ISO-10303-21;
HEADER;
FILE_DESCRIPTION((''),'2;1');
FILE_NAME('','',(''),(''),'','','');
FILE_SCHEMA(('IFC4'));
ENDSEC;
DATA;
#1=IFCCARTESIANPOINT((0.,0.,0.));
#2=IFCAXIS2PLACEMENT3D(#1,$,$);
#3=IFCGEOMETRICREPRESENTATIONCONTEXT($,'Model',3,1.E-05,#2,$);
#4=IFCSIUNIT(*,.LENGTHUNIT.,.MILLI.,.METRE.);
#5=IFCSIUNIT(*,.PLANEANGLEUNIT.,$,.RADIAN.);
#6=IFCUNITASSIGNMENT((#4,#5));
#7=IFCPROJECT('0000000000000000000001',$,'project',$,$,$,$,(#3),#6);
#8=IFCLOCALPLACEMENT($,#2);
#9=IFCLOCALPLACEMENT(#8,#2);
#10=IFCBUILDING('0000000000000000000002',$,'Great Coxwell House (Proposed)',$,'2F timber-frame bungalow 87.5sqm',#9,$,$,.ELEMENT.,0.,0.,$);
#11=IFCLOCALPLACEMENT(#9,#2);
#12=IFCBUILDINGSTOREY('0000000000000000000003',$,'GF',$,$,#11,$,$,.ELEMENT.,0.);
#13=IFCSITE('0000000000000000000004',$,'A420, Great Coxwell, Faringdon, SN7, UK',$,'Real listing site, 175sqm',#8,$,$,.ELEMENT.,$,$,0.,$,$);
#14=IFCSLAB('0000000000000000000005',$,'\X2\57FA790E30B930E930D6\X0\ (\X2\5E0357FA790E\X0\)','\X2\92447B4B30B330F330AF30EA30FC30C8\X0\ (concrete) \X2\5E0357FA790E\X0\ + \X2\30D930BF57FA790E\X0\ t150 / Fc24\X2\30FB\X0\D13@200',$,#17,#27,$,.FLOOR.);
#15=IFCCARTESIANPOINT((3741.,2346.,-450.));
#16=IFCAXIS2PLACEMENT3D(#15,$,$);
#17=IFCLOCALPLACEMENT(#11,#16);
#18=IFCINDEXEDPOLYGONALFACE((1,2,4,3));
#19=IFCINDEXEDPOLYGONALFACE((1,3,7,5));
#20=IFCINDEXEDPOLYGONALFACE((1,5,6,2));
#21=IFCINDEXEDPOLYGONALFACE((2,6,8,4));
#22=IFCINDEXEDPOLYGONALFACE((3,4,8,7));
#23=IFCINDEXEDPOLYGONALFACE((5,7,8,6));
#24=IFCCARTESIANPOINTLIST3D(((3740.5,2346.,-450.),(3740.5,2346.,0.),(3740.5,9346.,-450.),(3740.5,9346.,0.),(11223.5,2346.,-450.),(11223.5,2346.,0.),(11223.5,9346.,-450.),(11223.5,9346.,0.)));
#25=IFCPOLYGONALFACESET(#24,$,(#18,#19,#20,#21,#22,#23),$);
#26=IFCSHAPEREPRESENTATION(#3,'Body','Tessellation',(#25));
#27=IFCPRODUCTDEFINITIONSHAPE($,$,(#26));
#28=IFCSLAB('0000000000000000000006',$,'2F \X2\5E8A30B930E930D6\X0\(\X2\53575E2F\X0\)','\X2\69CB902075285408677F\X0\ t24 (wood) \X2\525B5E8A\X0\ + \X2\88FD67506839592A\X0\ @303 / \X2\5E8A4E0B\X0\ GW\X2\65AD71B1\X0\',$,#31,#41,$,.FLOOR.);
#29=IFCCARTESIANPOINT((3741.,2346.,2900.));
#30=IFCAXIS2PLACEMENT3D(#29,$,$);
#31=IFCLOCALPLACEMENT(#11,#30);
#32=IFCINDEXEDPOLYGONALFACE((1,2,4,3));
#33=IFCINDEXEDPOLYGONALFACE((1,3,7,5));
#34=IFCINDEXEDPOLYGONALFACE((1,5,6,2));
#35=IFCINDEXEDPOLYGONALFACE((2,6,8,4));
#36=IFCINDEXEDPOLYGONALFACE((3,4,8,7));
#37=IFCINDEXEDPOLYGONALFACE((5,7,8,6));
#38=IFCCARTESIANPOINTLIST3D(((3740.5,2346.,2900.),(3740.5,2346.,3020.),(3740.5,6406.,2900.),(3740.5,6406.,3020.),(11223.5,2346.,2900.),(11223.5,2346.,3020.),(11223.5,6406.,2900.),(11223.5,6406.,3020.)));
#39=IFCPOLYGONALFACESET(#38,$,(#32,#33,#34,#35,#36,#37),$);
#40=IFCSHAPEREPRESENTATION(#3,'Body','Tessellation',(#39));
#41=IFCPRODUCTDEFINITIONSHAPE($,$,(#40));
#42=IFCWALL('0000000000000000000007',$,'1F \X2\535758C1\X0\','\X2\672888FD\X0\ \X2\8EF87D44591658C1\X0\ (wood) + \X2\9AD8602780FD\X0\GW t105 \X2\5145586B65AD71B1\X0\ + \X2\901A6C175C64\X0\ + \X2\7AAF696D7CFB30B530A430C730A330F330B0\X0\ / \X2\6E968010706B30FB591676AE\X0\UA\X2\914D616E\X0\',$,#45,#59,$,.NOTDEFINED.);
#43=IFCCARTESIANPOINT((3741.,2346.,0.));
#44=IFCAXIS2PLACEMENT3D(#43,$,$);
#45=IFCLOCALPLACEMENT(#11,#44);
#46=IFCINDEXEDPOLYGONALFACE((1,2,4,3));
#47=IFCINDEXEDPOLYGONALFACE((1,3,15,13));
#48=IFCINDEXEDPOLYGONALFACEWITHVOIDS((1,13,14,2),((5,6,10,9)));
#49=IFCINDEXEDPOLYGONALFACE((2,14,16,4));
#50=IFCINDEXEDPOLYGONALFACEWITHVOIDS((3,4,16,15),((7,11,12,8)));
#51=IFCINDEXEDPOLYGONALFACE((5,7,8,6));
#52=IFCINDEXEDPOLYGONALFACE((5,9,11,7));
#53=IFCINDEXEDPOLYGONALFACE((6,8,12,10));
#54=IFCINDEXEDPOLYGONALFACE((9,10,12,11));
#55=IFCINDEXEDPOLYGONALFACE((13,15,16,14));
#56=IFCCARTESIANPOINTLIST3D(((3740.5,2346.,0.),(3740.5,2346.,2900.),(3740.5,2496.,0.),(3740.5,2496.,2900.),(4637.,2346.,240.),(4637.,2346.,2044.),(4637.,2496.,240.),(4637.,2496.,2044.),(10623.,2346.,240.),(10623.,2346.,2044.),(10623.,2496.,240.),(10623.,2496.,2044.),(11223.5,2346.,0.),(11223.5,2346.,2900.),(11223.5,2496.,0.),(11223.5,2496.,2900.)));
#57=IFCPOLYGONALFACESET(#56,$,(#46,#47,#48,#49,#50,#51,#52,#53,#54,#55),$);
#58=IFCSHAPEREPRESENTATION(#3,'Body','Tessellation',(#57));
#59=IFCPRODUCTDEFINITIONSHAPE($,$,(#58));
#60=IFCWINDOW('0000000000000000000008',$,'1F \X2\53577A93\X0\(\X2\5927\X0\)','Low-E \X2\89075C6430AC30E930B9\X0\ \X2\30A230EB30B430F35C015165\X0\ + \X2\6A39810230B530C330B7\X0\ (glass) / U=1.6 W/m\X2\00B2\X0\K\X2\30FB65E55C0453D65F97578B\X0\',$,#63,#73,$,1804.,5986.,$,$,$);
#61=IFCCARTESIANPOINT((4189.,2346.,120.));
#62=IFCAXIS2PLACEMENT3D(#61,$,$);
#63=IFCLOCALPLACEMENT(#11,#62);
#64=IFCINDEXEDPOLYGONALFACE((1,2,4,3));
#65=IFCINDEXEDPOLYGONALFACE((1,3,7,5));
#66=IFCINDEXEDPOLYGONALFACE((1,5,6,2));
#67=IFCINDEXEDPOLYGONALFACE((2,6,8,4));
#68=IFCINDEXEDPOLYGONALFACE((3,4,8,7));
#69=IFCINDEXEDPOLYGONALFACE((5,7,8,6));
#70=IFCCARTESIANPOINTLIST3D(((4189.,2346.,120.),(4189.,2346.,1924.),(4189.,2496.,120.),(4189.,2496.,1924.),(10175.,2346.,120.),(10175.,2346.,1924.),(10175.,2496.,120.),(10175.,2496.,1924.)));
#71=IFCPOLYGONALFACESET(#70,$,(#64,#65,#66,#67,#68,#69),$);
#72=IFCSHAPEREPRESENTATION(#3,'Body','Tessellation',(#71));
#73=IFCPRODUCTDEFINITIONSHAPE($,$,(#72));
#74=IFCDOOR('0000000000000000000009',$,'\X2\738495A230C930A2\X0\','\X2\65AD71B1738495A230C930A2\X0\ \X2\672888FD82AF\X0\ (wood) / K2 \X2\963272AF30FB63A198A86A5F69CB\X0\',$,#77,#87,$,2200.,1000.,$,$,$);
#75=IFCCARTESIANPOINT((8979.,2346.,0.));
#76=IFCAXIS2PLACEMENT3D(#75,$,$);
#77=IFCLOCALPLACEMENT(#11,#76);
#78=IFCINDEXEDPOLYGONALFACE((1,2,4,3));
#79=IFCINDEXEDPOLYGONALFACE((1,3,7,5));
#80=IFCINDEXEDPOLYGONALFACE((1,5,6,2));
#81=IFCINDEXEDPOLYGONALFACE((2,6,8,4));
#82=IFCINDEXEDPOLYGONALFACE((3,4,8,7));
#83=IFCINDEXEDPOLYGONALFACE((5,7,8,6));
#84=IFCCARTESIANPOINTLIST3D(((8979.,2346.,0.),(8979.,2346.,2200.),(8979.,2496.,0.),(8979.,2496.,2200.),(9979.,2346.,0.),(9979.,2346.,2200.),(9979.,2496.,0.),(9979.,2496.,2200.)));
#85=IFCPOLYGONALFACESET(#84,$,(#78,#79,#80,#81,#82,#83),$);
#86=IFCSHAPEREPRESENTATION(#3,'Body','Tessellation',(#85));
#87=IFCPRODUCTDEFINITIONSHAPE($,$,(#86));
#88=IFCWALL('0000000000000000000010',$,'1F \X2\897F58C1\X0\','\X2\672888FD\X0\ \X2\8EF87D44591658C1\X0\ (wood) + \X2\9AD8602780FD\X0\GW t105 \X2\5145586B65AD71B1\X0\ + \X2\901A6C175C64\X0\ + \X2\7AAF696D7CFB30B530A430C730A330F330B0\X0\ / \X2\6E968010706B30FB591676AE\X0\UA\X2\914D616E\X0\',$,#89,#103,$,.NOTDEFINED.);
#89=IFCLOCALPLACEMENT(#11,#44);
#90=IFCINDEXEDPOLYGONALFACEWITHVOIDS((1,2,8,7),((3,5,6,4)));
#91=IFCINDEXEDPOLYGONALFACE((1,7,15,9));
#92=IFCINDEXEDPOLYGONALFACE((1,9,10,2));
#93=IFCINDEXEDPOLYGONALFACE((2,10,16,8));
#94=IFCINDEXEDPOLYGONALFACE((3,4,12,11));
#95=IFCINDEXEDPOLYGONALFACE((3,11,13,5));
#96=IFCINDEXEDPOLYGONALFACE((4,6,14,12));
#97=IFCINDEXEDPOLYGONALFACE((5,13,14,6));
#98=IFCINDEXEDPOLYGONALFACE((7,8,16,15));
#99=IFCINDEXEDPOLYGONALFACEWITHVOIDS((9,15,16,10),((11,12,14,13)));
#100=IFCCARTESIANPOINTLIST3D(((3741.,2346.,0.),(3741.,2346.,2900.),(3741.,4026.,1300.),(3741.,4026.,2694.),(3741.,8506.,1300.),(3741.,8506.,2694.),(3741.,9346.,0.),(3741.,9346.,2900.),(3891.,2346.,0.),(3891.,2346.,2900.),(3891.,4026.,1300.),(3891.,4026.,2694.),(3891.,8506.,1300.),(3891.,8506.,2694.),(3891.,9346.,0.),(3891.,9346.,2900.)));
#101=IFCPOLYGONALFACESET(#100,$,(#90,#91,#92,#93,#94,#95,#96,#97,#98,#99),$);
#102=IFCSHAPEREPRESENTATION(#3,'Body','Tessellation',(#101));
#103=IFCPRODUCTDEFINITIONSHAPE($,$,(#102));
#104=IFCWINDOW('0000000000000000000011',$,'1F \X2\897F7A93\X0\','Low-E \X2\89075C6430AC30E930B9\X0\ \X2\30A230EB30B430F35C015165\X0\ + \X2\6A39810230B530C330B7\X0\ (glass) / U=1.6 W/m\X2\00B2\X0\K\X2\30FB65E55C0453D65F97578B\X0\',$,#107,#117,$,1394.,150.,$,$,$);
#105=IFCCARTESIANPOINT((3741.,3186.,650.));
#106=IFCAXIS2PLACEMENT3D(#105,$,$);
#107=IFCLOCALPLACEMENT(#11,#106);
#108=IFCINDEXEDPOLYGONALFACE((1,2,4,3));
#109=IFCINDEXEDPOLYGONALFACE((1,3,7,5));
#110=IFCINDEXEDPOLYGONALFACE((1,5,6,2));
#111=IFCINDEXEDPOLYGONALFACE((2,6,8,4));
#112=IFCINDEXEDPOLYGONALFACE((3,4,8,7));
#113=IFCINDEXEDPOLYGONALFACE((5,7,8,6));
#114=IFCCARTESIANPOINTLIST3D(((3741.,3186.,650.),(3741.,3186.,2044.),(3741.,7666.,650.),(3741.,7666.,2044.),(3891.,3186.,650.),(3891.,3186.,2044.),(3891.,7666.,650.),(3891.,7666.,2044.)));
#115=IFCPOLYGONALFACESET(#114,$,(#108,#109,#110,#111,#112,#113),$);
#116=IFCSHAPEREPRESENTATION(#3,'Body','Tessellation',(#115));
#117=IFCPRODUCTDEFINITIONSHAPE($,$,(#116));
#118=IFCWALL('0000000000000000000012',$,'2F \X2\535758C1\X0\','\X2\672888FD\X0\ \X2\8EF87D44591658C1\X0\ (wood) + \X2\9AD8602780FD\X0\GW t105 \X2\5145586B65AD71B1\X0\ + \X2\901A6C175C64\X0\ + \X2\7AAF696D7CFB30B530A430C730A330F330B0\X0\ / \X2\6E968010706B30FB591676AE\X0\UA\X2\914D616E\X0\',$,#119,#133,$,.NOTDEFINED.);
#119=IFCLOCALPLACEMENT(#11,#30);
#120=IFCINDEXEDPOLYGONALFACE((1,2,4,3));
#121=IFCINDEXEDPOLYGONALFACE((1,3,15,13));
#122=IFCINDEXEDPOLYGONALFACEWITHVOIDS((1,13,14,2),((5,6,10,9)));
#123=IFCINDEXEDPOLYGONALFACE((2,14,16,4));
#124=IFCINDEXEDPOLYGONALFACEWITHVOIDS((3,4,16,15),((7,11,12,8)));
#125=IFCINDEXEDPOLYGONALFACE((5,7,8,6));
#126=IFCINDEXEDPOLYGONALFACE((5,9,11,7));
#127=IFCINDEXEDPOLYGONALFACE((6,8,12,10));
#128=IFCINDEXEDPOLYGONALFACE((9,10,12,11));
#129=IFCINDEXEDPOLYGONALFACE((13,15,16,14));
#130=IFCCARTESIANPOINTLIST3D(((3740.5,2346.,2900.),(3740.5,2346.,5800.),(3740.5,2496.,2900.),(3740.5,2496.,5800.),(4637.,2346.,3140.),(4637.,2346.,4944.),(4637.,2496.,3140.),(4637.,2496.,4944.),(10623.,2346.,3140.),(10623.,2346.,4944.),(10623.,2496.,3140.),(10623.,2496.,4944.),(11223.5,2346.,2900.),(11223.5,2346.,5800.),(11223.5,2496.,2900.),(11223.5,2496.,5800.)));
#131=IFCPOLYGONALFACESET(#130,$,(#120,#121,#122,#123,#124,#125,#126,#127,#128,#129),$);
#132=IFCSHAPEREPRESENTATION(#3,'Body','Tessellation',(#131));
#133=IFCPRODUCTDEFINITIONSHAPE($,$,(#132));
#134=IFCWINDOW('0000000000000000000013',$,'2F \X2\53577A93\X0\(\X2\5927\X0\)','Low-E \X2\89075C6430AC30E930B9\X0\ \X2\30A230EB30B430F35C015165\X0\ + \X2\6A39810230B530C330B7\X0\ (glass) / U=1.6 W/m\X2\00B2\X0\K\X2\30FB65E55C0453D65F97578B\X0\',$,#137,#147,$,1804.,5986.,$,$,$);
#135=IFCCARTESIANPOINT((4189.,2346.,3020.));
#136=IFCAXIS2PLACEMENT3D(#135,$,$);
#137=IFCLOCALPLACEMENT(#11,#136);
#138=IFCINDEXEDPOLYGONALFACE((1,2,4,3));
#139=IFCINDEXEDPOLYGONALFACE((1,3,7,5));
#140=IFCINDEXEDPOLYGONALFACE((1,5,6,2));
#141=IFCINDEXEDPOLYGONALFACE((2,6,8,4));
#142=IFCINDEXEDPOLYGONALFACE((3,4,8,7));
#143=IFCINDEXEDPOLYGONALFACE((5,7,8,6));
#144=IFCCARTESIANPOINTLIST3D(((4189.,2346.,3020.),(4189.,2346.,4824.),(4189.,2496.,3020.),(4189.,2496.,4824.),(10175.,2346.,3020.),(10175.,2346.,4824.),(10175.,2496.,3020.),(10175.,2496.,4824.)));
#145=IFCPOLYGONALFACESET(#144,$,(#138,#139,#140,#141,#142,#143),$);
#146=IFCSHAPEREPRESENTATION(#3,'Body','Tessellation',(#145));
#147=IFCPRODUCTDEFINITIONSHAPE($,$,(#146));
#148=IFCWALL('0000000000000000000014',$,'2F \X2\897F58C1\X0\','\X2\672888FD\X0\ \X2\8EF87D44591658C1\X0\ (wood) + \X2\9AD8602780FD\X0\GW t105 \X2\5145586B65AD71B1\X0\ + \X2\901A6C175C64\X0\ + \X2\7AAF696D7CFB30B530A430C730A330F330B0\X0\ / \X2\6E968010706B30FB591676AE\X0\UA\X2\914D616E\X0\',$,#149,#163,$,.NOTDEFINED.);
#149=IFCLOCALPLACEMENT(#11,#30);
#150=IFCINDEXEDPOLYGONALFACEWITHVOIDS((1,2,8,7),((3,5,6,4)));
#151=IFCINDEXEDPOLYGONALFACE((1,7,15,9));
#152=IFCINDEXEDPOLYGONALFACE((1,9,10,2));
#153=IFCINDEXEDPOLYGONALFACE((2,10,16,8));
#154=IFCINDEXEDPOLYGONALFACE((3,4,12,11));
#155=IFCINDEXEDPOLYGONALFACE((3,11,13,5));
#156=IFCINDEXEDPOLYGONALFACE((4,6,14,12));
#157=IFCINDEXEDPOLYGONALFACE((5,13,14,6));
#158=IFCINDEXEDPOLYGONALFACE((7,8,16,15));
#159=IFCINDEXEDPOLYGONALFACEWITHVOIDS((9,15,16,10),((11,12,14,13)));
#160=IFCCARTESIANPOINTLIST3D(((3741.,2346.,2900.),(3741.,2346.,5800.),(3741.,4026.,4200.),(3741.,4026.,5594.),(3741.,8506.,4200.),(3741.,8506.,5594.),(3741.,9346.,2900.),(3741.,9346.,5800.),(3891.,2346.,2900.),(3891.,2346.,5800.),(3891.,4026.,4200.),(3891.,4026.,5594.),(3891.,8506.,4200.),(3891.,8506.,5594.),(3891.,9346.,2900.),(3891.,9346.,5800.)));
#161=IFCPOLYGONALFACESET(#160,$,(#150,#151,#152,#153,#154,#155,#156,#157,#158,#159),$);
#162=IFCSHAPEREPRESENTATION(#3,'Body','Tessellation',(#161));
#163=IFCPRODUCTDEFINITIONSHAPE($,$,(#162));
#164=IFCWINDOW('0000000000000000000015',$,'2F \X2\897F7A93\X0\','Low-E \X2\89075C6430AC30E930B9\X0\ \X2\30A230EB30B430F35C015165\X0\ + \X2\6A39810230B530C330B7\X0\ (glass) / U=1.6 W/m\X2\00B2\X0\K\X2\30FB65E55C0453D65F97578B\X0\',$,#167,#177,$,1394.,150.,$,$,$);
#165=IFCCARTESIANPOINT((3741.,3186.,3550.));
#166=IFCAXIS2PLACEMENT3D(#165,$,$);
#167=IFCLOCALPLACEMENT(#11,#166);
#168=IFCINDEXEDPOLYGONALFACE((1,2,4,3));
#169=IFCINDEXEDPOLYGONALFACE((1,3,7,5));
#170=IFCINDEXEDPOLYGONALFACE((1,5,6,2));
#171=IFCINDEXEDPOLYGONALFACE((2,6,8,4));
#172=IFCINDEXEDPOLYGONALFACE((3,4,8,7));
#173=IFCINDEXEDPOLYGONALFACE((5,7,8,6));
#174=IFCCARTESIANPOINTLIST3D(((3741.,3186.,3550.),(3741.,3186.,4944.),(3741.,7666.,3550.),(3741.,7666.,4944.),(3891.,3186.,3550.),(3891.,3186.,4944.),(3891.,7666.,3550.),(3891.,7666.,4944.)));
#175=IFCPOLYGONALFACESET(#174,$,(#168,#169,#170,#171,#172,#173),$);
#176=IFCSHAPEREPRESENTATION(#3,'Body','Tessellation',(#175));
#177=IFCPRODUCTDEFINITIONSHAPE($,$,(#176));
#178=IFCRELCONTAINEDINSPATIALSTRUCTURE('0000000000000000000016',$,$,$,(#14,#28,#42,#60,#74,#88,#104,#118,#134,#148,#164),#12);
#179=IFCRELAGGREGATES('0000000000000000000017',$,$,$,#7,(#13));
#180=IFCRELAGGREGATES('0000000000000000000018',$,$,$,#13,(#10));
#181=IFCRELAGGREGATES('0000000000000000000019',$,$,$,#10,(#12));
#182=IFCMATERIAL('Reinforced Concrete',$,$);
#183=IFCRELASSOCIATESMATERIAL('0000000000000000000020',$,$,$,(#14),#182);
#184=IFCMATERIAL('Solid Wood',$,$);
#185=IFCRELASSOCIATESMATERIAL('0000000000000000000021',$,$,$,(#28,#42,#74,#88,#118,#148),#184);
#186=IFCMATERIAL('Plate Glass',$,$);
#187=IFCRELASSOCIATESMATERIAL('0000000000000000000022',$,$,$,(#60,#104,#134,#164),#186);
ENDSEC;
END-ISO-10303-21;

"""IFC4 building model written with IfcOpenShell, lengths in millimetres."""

from ifc_helpers import new_model, si_unit, frame, frame_2d, origin, place, context, project, spatial, rectangle, extrude, material, element, fill, save


model = new_model("IFC4")

# Units and contexts
model_context = context("Model", 3, precision=1e-05, world=origin())
ifc_project = project(units=[si_unit("LENGTHUNIT", "METRE", prefix="MILLI"), si_unit("PLANEANGLEUNIT", "RADIAN")], contexts=[model_context])

# Site, building, storey
site_placement = place(None, origin())
site = spatial("IfcSite", under=ifc_project, at=site_placement, Name="A420, Great Coxwell, Faringdon, SN7, UK", ObjectType="Real listing site, 175sqm", CompositionType="ELEMENT", RefElevation=0.0)
building_placement = place(site_placement, origin())
building = spatial("IfcBuilding", under=site, at=building_placement, Name="Great Coxwell House (Proposed)", ObjectType="2F timber-frame bungalow 87.5sqm", CompositionType="ELEMENT", ElevationOfRefHeight=0.0, ElevationOfTerrain=0.0)
storey_placement = place(building_placement, origin())
storey = spatial("IfcBuildingStorey", under=building, at=storey_placement, Name="GF", CompositionType="ELEMENT", Elevation=0.0)

# Slabs
ifc_material_1 = material(Name="Reinforced Concrete")
slab_1_placement = place(storey_placement, frame((3741.0, 2346.0, -450.0)))
element("IfcSlab", 1, at=slab_1_placement, inside=storey, material=ifc_material_1, Name="基礎スラブ (布基礎)", Description="鉄筋コンクリート (concrete) 布基礎 + ベタ基礎 t150 / Fc24・D13@200", PredefinedType="FLOOR", context=model_context, shape_type="SweptSolid", body=[
    extrude(rectangle(XDim=7483.0, YDim=7000.0, at=frame_2d((3741.0, 3500.0))), frame((3741.0, 2346.0, -450.0)), (0.0, 0.0, 1.0), 450.0),
])
ifc_material_2 = material(Name="Solid Wood")
slab_2_placement = place(storey_placement, frame((3741.0, 2346.0, 2900.0)))
element("IfcSlab", 2, at=slab_2_placement, inside=storey, material=ifc_material_2, Name="2F 床スラブ(南帯)", Description="構造用合板 t24 (wood) 剛床 + 製材根太 @303 / 床下 GW断熱", PredefinedType="FLOOR", context=model_context, shape_type="SweptSolid", body=[
    extrude(rectangle(XDim=7483.0, YDim=4060.0, at=frame_2d((3741.0, 2030.0))), frame((3741.0, 2346.0, 2900.0)), (0.0, 0.0, 1.0), 120.0),
])

# Wall, openings, window, door
wall_1_placement = place(storey_placement, frame((3741.0, 2346.0, 0.0)))
wall_1 = element("IfcWall", 3, at=wall_1_placement, inside=storey, material=ifc_material_2, Name="1F 南壁", Description="木製 軸組外壁 (wood) + 高性能GW t105 充填断熱 + 通気層 + 窯業系サイディング / 準耐火・外皮UA配慮", PredefinedType="NOTDEFINED", context=model_context, shape_type="SweptSolid", body=[
    extrude(rectangle(XDim=7483.0, YDim=150.0, at=frame_2d((3741.0, 75.0))), frame((3741.0, 2346.0, 0.0)), (0.0, 0.0, 1.0), 2900.0),
])
opening_1_placement = place(storey_placement, frame((4189.0, 2346.0, 120.0)))
opening_1 = element("IfcOpeningElement", 4, at=opening_1_placement, cuts=wall_1, PredefinedType="NOTDEFINED", context=model_context, shape_type="SweptSolid", body=[
    extrude(rectangle(XDim=5986.0, YDim=150.0, at=frame_2d((2993.0, 75.0))), frame((4189.0, 2346.0, 120.0)), (0.0, 0.0, 1.0), 1804.0),
])
opening_2_placement = place(storey_placement, frame((8979.0, 2346.0, 0.0)))
opening_2 = element("IfcOpeningElement", 5, at=opening_2_placement, cuts=wall_1, PredefinedType="NOTDEFINED", context=model_context, shape_type="SweptSolid", body=[
    extrude(rectangle(XDim=1000.0, YDim=150.0, at=frame_2d((500.0, 75.0))), frame((8979.0, 2346.0, 0.0)), (0.0, 0.0, 1.0), 2200.0),
])
ifc_material_3 = material(Name="Plate Glass")
window_1_placement = place(storey_placement, frame((4189.0, 2346.0, 120.0)))
window_1 = element("IfcWindow", 6, at=window_1_placement, inside=storey, material=ifc_material_3, Name="1F 南窓(大)", Description="Low-E 複層ガラス アルゴン封入 + 樹脂サッシ (glass) / U=1.6 W/m²K・日射取得型", OverallHeight=1804.0, OverallWidth=5986.0, context=model_context, shape_type="SweptSolid", body=[
    extrude(rectangle(XDim=5986.0, YDim=150.0, at=frame_2d((2993.0, 75.0))), frame((4189.0, 2346.0, 120.0)), (0.0, 0.0, 1.0), 1804.0),
])
fill(opening_1, window_1)
door_placement = place(storey_placement, frame((8979.0, 2346.0, 0.0)))
door = element("IfcDoor", 7, at=door_placement, inside=storey, material=ifc_material_2, Name="玄関ドア", Description="断熱玄関ドア 木製芯 (wood) / K2 防犯・採風機構", OverallHeight=2200.0, OverallWidth=1000.0, context=model_context, shape_type="SweptSolid", body=[
    extrude(rectangle(XDim=1000.0, YDim=150.0, at=frame_2d((500.0, 75.0))), frame((8979.0, 2346.0, 0.0)), (0.0, 0.0, 1.0), 2200.0),
])
fill(opening_2, door)

# Wall, opening, window
wall_2_placement = place(storey_placement, frame((3741.0, 2346.0, 0.0)))
wall_2 = element("IfcWall", 8, at=wall_2_placement, inside=storey, material=ifc_material_2, Name="1F 西壁", Description="木製 軸組外壁 (wood) + 高性能GW t105 充填断熱 + 通気層 + 窯業系サイディング / 準耐火・外皮UA配慮", PredefinedType="NOTDEFINED", context=model_context, shape_type="SweptSolid", body=[
    extrude(rectangle(XDim=150.0, YDim=7000.0, at=frame_2d((75.0, 3500.0))), frame((3741.0, 2346.0, 0.0)), (0.0, 0.0, 1.0), 2900.0),
])
opening_3_placement = place(storey_placement, frame((3741.0, 3186.0, 650.0)))
opening_3 = element("IfcOpeningElement", 9, at=opening_3_placement, cuts=wall_2, PredefinedType="NOTDEFINED", context=model_context, shape_type="SweptSolid", body=[
    extrude(rectangle(XDim=150.0, YDim=4480.0, at=frame_2d((75.0, 2240.0))), frame((3741.0, 3186.0, 650.0)), (0.0, 0.0, 1.0), 1394.0),
])
window_2_placement = place(storey_placement, frame((3741.0, 3186.0, 650.0)))
window_2 = element("IfcWindow", 10, at=window_2_placement, inside=storey, material=ifc_material_3, Name="1F 西窓", Description="Low-E 複層ガラス アルゴン封入 + 樹脂サッシ (glass) / U=1.6 W/m²K・日射取得型", OverallHeight=1394.0, OverallWidth=150.0, context=model_context, shape_type="SweptSolid", body=[
    extrude(rectangle(XDim=150.0, YDim=4480.0, at=frame_2d((75.0, 2240.0))), frame((3741.0, 3186.0, 650.0)), (0.0, 0.0, 1.0), 1394.0),
])
fill(opening_3, window_2)

# Walls, openings, windows
wall_3_placement = place(storey_placement, frame((3741.0, 2346.0, 2900.0)))
wall_3 = element("IfcWall", 11, at=wall_3_placement, inside=storey, material=ifc_material_2, Name="2F 南壁", Description="木製 軸組外壁 (wood) + 高性能GW t105 充填断熱 + 通気層 + 窯業系サイディング / 準耐火・外皮UA配慮", PredefinedType="NOTDEFINED", context=model_context, shape_type="SweptSolid", body=[
    extrude(rectangle(XDim=7483.0, YDim=150.0, at=frame_2d((3741.0, 75.0))), frame((3741.0, 2346.0, 2900.0)), (0.0, 0.0, 1.0), 2900.0),
])
opening_4_placement = place(storey_placement, frame((4189.0, 2346.0, 3020.0)))
opening_4 = element("IfcOpeningElement", 12, at=opening_4_placement, cuts=wall_3, PredefinedType="NOTDEFINED", context=model_context, shape_type="SweptSolid", body=[
    extrude(rectangle(XDim=5986.0, YDim=150.0, at=frame_2d((2993.0, 75.0))), frame((4189.0, 2346.0, 3020.0)), (0.0, 0.0, 1.0), 1804.0),
])
window_3_placement = place(storey_placement, frame((4189.0, 2346.0, 3020.0)))
window_3 = element("IfcWindow", 13, at=window_3_placement, inside=storey, material=ifc_material_3, Name="2F 南窓(大)", Description="Low-E 複層ガラス アルゴン封入 + 樹脂サッシ (glass) / U=1.6 W/m²K・日射取得型", OverallHeight=1804.0, OverallWidth=5986.0, context=model_context, shape_type="SweptSolid", body=[
    extrude(rectangle(XDim=5986.0, YDim=150.0, at=frame_2d((2993.0, 75.0))), frame((4189.0, 2346.0, 3020.0)), (0.0, 0.0, 1.0), 1804.0),
])
fill(opening_4, window_3)
wall_4_placement = place(storey_placement, frame((3741.0, 2346.0, 2900.0)))
wall_4 = element("IfcWall", 14, at=wall_4_placement, inside=storey, material=ifc_material_2, Name="2F 西壁", Description="木製 軸組外壁 (wood) + 高性能GW t105 充填断熱 + 通気層 + 窯業系サイディング / 準耐火・外皮UA配慮", PredefinedType="NOTDEFINED", context=model_context, shape_type="SweptSolid", body=[
    extrude(rectangle(XDim=150.0, YDim=7000.0, at=frame_2d((75.0, 3500.0))), frame((3741.0, 2346.0, 2900.0)), (0.0, 0.0, 1.0), 2900.0),
])
opening_5_placement = place(storey_placement, frame((3741.0, 3186.0, 3550.0)))
opening_5 = element("IfcOpeningElement", 15, at=opening_5_placement, cuts=wall_4, PredefinedType="NOTDEFINED", context=model_context, shape_type="SweptSolid", body=[
    extrude(rectangle(XDim=150.0, YDim=4480.0, at=frame_2d((75.0, 2240.0))), frame((3741.0, 3186.0, 3550.0)), (0.0, 0.0, 1.0), 1394.0),
])
window_4_placement = place(storey_placement, frame((3741.0, 3186.0, 3550.0)))
window_4 = element("IfcWindow", 16, at=window_4_placement, inside=storey, material=ifc_material_3, Name="2F 西窓", Description="Low-E 複層ガラス アルゴン封入 + 樹脂サッシ (glass) / U=1.6 W/m²K・日射取得型", OverallHeight=1394.0, OverallWidth=150.0, context=model_context, shape_type="SweptSolid", body=[
    extrude(rectangle(XDim=150.0, YDim=4480.0, at=frame_2d((75.0, 2240.0))), frame((3741.0, 3186.0, 3550.0)), (0.0, 0.0, 1.0), 1394.0),
])
fill(opening_5, window_4)

save(model, "model.ifc")
